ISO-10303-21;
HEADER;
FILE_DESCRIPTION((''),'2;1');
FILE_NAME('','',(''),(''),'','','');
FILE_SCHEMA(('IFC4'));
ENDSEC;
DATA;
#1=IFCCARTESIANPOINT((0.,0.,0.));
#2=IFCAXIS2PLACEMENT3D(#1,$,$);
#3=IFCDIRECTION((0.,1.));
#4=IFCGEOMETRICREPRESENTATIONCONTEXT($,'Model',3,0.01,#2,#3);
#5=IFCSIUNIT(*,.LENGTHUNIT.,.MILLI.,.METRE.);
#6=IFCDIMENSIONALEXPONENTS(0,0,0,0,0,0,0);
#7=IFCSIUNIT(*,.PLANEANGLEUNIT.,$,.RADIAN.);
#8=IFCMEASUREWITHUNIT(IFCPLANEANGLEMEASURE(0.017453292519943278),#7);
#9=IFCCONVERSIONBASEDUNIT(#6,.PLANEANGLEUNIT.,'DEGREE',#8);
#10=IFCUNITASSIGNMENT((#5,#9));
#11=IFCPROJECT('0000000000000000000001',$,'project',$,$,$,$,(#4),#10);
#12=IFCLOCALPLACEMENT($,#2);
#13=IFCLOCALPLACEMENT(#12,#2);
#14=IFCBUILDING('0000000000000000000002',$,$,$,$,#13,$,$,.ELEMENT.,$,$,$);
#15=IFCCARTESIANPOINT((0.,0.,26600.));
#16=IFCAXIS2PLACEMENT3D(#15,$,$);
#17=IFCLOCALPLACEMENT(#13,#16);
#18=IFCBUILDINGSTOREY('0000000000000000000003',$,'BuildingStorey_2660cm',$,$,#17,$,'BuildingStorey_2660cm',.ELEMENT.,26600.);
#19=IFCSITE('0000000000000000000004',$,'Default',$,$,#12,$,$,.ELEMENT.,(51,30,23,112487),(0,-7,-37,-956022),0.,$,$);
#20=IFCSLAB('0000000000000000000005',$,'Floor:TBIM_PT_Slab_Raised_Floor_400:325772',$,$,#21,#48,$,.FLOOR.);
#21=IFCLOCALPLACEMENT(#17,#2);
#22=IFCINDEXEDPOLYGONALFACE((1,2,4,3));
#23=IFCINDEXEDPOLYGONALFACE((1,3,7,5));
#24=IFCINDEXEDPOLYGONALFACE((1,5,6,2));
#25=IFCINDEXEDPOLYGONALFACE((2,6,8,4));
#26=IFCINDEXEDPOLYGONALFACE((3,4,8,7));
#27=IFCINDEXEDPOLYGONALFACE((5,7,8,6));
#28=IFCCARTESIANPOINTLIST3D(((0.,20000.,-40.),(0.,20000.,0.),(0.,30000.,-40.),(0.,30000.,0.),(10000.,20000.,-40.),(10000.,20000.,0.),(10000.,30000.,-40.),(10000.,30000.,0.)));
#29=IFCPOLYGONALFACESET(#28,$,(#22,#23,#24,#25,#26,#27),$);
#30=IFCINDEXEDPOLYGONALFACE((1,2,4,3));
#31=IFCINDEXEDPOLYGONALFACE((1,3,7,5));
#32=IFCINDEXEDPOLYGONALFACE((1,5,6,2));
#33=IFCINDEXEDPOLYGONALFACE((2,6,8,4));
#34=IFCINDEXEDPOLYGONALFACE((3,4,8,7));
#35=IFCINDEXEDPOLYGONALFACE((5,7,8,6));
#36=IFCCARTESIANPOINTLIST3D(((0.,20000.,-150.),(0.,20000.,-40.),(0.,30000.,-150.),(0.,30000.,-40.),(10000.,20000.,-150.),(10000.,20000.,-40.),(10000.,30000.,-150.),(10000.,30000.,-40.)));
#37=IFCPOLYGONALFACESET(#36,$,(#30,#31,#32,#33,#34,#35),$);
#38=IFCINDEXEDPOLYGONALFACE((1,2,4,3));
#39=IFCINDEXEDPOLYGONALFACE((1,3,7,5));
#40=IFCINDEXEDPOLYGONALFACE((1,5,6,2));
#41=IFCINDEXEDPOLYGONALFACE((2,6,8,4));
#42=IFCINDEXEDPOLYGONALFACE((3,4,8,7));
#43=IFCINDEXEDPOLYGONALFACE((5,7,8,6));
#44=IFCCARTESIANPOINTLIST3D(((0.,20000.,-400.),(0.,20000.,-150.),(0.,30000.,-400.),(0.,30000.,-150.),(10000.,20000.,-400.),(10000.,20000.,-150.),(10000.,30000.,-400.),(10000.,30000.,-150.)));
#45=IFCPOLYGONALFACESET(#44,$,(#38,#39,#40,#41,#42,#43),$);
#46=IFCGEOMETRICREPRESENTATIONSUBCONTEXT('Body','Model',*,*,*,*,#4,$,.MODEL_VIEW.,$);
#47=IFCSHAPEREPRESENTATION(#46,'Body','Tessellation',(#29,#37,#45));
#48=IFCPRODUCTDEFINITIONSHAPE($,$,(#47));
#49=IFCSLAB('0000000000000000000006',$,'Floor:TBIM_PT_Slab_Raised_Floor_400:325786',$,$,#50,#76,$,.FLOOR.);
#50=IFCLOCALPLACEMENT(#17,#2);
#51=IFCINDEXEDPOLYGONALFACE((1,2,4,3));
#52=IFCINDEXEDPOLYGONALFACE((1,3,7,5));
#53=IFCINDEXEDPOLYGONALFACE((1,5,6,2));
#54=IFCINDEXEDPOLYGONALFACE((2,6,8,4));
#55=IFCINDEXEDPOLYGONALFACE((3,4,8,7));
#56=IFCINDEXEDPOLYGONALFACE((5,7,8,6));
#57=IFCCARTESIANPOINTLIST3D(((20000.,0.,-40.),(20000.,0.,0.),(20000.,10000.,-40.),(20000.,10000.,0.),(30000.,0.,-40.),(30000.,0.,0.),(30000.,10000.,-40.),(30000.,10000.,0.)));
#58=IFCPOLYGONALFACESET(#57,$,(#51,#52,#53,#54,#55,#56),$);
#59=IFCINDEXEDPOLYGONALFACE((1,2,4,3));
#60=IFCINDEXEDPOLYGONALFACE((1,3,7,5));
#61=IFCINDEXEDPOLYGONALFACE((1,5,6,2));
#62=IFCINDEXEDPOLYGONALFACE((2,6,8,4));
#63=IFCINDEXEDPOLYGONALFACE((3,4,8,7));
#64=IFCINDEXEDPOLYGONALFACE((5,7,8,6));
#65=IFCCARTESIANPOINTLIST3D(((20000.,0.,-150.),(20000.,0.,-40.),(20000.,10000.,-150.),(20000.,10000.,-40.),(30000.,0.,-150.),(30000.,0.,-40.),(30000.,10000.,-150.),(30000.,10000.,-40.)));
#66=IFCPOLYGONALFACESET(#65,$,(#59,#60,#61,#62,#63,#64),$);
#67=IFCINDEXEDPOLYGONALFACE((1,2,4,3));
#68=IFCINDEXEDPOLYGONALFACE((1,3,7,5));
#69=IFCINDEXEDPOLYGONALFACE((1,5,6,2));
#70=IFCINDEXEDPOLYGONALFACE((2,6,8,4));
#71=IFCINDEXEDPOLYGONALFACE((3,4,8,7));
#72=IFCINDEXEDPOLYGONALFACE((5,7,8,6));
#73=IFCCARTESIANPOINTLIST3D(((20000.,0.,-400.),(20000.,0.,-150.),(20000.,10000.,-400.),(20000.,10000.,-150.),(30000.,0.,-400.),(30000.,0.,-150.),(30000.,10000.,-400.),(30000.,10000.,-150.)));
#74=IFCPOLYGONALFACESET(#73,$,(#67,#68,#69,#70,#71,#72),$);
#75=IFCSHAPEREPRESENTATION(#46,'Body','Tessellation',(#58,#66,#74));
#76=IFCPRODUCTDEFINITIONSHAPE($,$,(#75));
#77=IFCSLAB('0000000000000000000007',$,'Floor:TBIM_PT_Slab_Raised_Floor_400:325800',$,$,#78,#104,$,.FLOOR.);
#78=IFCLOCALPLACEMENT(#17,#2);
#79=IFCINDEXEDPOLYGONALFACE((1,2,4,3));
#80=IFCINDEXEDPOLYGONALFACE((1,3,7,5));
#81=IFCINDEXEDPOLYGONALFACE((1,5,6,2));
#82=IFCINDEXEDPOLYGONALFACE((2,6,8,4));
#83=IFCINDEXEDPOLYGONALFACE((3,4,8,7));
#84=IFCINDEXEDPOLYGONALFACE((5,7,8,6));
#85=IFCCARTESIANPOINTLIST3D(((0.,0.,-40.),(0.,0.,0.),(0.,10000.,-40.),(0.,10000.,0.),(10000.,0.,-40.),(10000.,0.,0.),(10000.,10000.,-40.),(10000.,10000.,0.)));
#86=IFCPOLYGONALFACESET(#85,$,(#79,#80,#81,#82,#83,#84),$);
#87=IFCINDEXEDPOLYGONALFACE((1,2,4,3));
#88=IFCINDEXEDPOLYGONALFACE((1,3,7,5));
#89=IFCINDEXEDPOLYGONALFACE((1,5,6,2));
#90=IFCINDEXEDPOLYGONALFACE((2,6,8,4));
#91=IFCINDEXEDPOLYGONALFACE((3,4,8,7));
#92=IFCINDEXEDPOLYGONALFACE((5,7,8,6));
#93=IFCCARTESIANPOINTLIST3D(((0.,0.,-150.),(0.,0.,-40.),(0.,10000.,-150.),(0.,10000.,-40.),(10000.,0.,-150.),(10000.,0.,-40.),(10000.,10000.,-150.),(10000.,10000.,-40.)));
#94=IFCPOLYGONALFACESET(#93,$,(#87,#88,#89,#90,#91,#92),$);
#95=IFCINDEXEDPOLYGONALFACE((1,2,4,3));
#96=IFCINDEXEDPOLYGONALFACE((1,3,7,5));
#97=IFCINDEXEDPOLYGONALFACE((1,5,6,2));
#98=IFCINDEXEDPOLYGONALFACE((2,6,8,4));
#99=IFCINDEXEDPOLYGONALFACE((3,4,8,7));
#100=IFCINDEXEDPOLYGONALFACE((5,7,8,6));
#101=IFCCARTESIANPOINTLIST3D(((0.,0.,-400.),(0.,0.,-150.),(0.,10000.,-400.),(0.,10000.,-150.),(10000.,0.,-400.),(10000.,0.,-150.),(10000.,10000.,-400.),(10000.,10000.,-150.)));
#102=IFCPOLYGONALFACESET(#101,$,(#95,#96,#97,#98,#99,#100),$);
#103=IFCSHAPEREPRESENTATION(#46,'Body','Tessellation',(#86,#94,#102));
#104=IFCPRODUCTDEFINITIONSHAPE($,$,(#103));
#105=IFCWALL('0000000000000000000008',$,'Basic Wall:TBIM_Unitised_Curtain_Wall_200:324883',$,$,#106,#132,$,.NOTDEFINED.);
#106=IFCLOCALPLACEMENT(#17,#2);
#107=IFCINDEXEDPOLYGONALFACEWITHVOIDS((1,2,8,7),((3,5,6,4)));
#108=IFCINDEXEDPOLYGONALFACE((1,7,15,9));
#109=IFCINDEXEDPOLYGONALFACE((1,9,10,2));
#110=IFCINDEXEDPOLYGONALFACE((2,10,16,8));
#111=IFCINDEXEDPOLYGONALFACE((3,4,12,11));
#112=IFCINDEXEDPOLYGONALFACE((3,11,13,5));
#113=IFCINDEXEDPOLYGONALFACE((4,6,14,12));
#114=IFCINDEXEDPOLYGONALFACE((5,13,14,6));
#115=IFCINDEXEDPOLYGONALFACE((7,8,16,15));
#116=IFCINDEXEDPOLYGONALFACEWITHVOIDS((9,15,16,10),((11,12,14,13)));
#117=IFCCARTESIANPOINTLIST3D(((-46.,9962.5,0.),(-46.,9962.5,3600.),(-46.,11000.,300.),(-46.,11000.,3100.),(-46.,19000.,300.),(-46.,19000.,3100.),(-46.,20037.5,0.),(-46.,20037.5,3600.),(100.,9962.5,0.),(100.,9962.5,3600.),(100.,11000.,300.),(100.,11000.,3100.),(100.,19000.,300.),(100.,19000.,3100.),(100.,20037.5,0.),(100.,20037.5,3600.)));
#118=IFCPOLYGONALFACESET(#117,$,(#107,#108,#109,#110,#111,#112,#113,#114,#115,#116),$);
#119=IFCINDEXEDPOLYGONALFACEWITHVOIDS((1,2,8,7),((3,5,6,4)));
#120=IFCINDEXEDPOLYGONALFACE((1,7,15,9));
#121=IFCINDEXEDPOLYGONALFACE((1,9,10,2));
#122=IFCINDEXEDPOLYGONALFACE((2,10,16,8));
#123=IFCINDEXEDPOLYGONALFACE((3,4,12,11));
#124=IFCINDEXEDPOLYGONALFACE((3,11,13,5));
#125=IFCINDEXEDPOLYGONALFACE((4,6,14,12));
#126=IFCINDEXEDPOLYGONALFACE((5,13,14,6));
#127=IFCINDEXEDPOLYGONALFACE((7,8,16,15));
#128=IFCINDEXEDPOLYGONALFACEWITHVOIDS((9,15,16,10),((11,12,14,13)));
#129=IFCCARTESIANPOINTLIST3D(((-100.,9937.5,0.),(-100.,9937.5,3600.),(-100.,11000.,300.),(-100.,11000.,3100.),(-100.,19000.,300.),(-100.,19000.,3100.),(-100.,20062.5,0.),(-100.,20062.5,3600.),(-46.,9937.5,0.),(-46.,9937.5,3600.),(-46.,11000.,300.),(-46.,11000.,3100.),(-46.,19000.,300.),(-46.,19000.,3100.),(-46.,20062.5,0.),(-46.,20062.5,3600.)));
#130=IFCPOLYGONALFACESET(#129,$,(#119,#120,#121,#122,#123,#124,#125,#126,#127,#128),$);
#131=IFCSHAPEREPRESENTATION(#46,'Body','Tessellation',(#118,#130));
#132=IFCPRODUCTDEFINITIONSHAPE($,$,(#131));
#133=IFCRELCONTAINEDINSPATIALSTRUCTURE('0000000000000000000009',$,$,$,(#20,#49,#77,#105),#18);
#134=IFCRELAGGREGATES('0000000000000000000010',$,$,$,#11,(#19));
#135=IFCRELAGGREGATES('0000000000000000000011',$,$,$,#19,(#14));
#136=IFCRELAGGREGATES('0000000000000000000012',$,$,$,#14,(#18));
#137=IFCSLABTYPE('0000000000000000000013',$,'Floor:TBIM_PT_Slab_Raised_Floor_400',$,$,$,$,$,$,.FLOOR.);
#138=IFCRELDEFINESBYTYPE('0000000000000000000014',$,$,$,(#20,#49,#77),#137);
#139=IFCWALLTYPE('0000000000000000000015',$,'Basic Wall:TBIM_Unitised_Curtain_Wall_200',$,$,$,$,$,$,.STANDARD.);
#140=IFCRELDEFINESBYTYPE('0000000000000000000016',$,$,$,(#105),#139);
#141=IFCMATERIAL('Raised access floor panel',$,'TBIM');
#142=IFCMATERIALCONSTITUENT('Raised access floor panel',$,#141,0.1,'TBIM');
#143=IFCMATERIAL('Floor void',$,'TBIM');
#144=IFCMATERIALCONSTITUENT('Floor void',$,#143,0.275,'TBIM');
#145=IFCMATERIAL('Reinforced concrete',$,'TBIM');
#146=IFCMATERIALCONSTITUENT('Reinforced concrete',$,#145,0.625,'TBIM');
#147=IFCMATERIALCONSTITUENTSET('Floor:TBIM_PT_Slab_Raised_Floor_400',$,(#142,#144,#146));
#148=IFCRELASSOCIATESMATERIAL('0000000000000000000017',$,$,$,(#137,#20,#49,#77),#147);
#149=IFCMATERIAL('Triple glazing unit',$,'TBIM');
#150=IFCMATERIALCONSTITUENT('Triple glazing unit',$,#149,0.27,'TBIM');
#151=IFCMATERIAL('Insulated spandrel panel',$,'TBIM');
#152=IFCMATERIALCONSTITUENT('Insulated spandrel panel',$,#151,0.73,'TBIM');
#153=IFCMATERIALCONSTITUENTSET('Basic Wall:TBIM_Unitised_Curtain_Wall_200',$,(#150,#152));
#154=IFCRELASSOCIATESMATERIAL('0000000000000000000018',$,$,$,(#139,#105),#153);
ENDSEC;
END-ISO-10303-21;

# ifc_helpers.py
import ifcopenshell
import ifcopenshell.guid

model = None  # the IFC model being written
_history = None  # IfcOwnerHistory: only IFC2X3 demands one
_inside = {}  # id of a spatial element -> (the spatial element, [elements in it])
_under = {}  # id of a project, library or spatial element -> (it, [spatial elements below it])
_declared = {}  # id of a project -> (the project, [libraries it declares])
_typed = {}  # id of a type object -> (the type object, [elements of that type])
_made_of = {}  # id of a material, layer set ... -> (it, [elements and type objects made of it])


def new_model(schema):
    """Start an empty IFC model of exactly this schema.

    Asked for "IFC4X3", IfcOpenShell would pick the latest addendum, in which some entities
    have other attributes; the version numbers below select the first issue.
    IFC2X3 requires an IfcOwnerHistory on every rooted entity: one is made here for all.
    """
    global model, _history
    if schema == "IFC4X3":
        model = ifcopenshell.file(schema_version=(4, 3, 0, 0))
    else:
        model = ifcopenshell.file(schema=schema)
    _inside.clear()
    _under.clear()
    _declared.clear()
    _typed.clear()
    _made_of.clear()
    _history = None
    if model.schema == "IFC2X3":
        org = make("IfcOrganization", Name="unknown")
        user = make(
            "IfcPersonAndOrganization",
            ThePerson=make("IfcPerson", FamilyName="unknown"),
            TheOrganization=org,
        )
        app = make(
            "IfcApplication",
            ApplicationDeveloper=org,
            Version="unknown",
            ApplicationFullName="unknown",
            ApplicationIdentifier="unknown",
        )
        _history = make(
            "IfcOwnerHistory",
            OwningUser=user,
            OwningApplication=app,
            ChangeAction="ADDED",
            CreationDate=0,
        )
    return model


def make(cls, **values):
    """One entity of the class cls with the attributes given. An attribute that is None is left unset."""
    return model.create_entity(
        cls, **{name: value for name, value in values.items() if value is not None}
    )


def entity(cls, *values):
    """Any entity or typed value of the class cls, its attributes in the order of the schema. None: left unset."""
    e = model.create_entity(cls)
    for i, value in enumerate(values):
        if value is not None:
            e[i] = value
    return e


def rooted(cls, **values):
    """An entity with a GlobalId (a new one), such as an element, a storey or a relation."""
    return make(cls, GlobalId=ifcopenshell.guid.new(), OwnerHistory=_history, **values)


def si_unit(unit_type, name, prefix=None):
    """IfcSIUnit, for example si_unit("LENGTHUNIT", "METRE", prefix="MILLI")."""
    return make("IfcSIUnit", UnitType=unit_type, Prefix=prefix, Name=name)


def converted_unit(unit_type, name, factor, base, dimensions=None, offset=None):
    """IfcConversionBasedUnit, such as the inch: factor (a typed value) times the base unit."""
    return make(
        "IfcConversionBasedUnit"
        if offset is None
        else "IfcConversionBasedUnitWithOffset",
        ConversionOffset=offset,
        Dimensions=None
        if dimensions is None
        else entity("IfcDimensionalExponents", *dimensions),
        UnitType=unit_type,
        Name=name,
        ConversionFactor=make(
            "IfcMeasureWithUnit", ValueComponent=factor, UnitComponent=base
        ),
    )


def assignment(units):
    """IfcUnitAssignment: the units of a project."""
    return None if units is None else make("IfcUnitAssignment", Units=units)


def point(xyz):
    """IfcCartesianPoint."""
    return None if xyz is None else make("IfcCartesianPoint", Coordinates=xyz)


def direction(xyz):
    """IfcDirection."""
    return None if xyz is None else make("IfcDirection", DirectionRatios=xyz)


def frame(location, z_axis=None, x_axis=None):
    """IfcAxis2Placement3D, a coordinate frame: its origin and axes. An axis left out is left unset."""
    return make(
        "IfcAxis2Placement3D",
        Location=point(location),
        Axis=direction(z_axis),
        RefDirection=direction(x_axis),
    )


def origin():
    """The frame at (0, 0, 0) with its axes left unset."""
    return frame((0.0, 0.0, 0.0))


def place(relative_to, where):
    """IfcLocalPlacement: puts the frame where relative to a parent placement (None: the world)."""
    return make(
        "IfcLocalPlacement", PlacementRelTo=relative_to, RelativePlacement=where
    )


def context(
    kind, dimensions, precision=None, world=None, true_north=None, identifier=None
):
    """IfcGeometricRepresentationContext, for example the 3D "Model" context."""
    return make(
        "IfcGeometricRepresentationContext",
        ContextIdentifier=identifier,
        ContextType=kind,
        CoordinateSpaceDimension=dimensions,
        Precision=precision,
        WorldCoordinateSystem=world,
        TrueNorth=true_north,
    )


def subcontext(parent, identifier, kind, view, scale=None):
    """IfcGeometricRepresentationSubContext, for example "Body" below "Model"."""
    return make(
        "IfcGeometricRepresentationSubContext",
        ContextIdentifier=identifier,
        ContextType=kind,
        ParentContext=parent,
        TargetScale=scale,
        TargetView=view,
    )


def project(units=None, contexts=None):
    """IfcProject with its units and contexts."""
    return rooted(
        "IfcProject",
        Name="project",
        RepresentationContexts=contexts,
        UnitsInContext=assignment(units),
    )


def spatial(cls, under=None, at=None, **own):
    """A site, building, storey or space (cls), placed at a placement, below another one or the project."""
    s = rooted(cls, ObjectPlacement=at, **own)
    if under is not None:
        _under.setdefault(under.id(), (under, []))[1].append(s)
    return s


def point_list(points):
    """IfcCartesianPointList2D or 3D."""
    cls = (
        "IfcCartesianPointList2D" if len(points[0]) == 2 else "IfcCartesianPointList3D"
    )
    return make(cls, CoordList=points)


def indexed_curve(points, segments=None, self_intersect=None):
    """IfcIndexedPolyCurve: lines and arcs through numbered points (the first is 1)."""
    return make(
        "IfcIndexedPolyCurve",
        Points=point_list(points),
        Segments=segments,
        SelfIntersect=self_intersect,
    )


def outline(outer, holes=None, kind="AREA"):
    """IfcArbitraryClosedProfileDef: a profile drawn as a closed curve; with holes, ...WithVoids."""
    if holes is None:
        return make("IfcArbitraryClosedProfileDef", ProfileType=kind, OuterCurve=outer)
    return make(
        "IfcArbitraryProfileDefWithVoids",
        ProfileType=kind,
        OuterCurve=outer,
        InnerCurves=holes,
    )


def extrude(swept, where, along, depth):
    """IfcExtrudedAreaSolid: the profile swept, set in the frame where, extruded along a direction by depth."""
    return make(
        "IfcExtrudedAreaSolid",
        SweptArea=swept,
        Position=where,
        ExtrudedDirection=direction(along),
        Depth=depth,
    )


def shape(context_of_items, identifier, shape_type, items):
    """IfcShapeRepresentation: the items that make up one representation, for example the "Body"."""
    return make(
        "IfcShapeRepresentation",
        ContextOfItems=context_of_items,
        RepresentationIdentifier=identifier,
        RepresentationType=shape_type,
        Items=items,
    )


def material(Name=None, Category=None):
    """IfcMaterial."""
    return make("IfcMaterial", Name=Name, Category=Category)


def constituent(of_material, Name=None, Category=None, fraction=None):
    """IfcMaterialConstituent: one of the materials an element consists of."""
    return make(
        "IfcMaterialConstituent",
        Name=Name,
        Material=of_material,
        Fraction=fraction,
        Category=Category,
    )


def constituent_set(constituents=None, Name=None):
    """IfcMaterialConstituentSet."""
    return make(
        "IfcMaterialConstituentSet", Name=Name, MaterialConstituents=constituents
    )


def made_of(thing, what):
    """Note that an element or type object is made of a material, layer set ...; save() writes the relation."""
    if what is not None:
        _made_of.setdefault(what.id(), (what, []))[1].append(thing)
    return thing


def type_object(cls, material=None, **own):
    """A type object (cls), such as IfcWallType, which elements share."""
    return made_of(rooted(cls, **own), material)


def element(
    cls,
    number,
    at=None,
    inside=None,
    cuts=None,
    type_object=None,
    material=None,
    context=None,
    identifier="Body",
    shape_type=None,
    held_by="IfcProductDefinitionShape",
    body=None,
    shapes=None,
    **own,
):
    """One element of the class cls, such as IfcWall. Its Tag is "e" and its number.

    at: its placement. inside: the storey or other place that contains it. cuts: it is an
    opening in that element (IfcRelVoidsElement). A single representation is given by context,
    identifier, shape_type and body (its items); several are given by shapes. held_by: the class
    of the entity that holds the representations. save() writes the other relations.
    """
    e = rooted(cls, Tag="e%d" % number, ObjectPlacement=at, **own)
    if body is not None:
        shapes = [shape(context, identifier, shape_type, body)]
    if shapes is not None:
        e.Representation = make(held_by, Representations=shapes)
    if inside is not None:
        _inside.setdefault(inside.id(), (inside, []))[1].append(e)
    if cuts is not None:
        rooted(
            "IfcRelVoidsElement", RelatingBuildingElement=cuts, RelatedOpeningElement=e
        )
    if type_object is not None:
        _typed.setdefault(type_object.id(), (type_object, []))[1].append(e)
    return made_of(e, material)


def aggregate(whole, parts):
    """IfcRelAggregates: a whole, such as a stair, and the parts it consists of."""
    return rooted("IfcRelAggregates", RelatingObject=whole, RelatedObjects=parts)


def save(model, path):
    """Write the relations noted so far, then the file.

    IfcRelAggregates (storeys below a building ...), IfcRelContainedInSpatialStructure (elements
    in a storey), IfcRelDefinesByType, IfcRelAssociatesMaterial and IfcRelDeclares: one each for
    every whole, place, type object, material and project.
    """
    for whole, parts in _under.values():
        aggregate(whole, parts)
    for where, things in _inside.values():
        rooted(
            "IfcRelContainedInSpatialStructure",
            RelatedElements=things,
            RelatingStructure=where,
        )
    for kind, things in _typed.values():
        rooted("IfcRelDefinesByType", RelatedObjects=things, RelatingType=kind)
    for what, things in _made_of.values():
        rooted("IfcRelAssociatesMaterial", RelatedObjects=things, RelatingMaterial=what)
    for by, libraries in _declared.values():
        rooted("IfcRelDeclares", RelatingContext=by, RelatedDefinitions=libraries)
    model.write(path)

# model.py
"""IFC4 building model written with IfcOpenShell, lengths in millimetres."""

from ifc_helpers import new_model, entity, si_unit, converted_unit, direction, frame, origin, place, context, subcontext, project, spatial, indexed_curve, outline, extrude, material, constituent, constituent_set, type_object, element, save


model = new_model("IFC4")

# Units and contexts
model_context = context("Model", 3, precision=0.01, world=origin(), true_north=direction((0.0, 1.0)))
body_context = subcontext(model_context, "Body", "Model", "MODEL_VIEW")
ifc_project = project(units=[si_unit("LENGTHUNIT", "METRE", prefix="MILLI"), converted_unit("PLANEANGLEUNIT", "DEGREE", entity("IfcPlaneAngleMeasure", 0.017453292519943278), si_unit("PLANEANGLEUNIT", "RADIAN"), dimensions=[0, 0, 0, 0, 0, 0, 0])], contexts=[model_context])

# Site, building, storey
site_placement = place(None, origin())
site = spatial("IfcSite", under=ifc_project, at=site_placement, Name="Default", CompositionType="ELEMENT", RefLatitude=(51, 30, 23, 112487), RefLongitude=(0, -7, -37, -956022), RefElevation=0.0)
building_placement = place(site_placement, origin())
building = spatial("IfcBuilding", under=site, at=building_placement, CompositionType="ELEMENT")
storey_placement = place(building_placement, frame((0.0, 0.0, 26600.0)))
storey = spatial("IfcBuildingStorey", under=building, at=storey_placement, Name="BuildingStorey_2660cm", LongName="BuildingStorey_2660cm", CompositionType="ELEMENT", Elevation=26600.0)

# Slabs
ifc_material_1 = material(Name="Raised access floor panel", Category="TBIM")
ifc_constituent_1 = constituent(ifc_material_1, Name="Raised access floor panel", Category="TBIM", fraction=0.1)
ifc_material_2 = material(Name="Floor void", Category="TBIM")
ifc_constituent_2 = constituent(ifc_material_2, Name="Floor void", Category="TBIM", fraction=0.275)
ifc_material_3 = material(Name="Reinforced concrete", Category="TBIM")
ifc_constituent_3 = constituent(ifc_material_3, Name="Reinforced concrete", Category="TBIM", fraction=0.625)
ifc_constituent_set_1 = constituent_set(constituents=[ifc_constituent_1, ifc_constituent_2, ifc_constituent_3], Name="Floor:TBIM_PT_Slab_Raised_Floor_400")
slab_type = type_object("IfcSlabType", Name="Floor:TBIM_PT_Slab_Raised_Floor_400", PredefinedType="FLOOR", material=ifc_constituent_set_1)
slab_1_placement = place(storey_placement, origin())
element("IfcSlab", 1, at=slab_1_placement, inside=storey, type_object=slab_type, material=ifc_constituent_set_1, Name="Floor:TBIM_PT_Slab_Raised_Floor_400:325772", PredefinedType="FLOOR", context=body_context, shape_type="SweptSolid", body=[
    extrude(outline(indexed_curve([(-5000.0, -5000.0), (5000.0, -5000.0), (5000.0, 5000.0), (-5000.0, 5000.0), (-5000.0, -5000.0)], self_intersect=False)), frame((5000.0, 25000.0, -40.0), z_axis=(0.0, 0.0, 1.0), x_axis=(-1.0, 0.0, 0.0)), (0.0, 0.0, 1.0), 40.0),
    extrude(outline(indexed_curve([(-5000.0, -5000.0), (5000.0, -5000.0), (5000.0, 5000.0), (-5000.0, 5000.0), (-5000.0, -5000.0)], self_intersect=False)), frame((5000.0, 25000.0, -150.0), z_axis=(0.0, 0.0, 1.0), x_axis=(-1.0, 0.0, 0.0)), (0.0, 0.0, 1.0), 110.0),
    extrude(outline(indexed_curve([(-5000.0, -5000.0), (5000.0, -5000.0), (5000.0, 5000.0), (-5000.0, 5000.0), (-5000.0, -5000.0)], self_intersect=False)), frame((5000.0, 25000.0, -400.0), z_axis=(0.0, 0.0, 1.0), x_axis=(-1.0, 0.0, 0.0)), (0.0, 0.0, 1.0), 250.0),
])
slab_2_placement = place(storey_placement, origin())
element("IfcSlab", 2, at=slab_2_placement, inside=storey, type_object=slab_type, material=ifc_constituent_set_1, Name="Floor:TBIM_PT_Slab_Raised_Floor_400:325786", PredefinedType="FLOOR", context=body_context, shape_type="SweptSolid", body=[
    extrude(outline(indexed_curve([(-5000.0, -5000.0), (5000.0, -5000.0), (5000.0, 5000.0), (-5000.0, 5000.0), (-5000.0, -5000.0)], self_intersect=False)), frame((25000.0, 5000.0, -40.0), z_axis=(0.0, 0.0, 1.0), x_axis=(-1.0, 0.0, 0.0)), (0.0, 0.0, 1.0), 40.0),
    extrude(outline(indexed_curve([(-5000.0, -5000.0), (5000.0, -5000.0), (5000.0, 5000.0), (-5000.0, 5000.0), (-5000.0, -5000.0)], self_intersect=False)), frame((25000.0, 5000.0, -150.0), z_axis=(0.0, 0.0, 1.0), x_axis=(-1.0, 0.0, 0.0)), (0.0, 0.0, 1.0), 110.0),
    extrude(outline(indexed_curve([(-5000.0, -5000.0), (5000.0, -5000.0), (5000.0, 5000.0), (-5000.0, 5000.0), (-5000.0, -5000.0)], self_intersect=False)), frame((25000.0, 5000.0, -400.0), z_axis=(0.0, 0.0, 1.0), x_axis=(-1.0, 0.0, 0.0)), (0.0, 0.0, 1.0), 250.0),
])
slab_3_placement = place(storey_placement, origin())
element("IfcSlab", 3, at=slab_3_placement, inside=storey, type_object=slab_type, material=ifc_constituent_set_1, Name="Floor:TBIM_PT_Slab_Raised_Floor_400:325800", PredefinedType="FLOOR", context=body_context, shape_type="SweptSolid", body=[
    extrude(outline(indexed_curve([(-5000.0, -5000.0), (5000.0, -5000.0), (5000.0, 5000.0), (-5000.0, 5000.0), (-5000.0, -5000.0)], self_intersect=False)), frame((5000.0, 5000.0, -40.0), z_axis=(0.0, 0.0, 1.0), x_axis=(-1.0, 0.0, 0.0)), (0.0, 0.0, 1.0), 40.0),
    extrude(outline(indexed_curve([(-5000.0, -5000.0), (5000.0, -5000.0), (5000.0, 5000.0), (-5000.0, 5000.0), (-5000.0, -5000.0)], self_intersect=False)), frame((5000.0, 5000.0, -150.0), z_axis=(0.0, 0.0, 1.0), x_axis=(-1.0, 0.0, 0.0)), (0.0, 0.0, 1.0), 110.0),
    extrude(outline(indexed_curve([(-5000.0, -5000.0), (5000.0, -5000.0), (5000.0, 5000.0), (-5000.0, 5000.0), (-5000.0, -5000.0)], self_intersect=False)), frame((5000.0, 5000.0, -400.0), z_axis=(0.0, 0.0, 1.0), x_axis=(-1.0, 0.0, 0.0)), (0.0, 0.0, 1.0), 250.0),
])

# Wall, opening
ifc_material_4 = material(Name="Triple glazing unit", Category="TBIM")
ifc_constituent_4 = constituent(ifc_material_4, Name="Triple glazing unit", Category="TBIM", fraction=0.27)
ifc_material_5 = material(Name="Insulated spandrel panel", Category="TBIM")
ifc_constituent_5 = constituent(ifc_material_5, Name="Insulated spandrel panel", Category="TBIM", fraction=0.73)
ifc_constituent_set_2 = constituent_set(constituents=[ifc_constituent_4, ifc_constituent_5], Name="Basic Wall:TBIM_Unitised_Curtain_Wall_200")
wall_type = type_object("IfcWallType", Name="Basic Wall:TBIM_Unitised_Curtain_Wall_200", PredefinedType="STANDARD", material=ifc_constituent_set_2)
wall_1_placement = place(storey_placement, frame((0.0, 9937.5, 0.0), z_axis=(0.0, 0.0, 1.0), x_axis=(0.0, 1.0, 0.0)))
wall_1 = element("IfcWall", 4, at=wall_1_placement, inside=storey, type_object=wall_type, material=ifc_constituent_set_2, Name="Basic Wall:TBIM_Unitised_Curtain_Wall_200:324883", PredefinedType="NOTDEFINED", context=body_context, shape_type="SweptSolid", body=[
    extrude(outline(indexed_curve([(-1800.0, -5037.5), (1800.0, -5037.5), (1800.0, 5037.5), (-1800.0, 5037.5), (-1800.0, -5037.5)], self_intersect=False), holes=[indexed_curve([(1300.0, 4000.0), (1300.0, -4000.0), (-1500.0, -4000.0), (-1500.0, 4000.0), (1300.0, 4000.0)], self_intersect=False)]), frame((5062.5, 46.0, 1800.0), z_axis=(0.0, -1.0, 0.0), x_axis=(0.0, 0.0, 1.0)), (0.0, 0.0, 1.0), 146.0),
    extrude(outline(indexed_curve([(-5062.5, -1800.0), (5062.5, -1800.0), (5062.5, 1800.0), (-5062.5, 1800.0), (-5062.5, -1800.0)], self_intersect=False), holes=[indexed_curve([(-4000.0, 1300.0), (4000.0, 1300.0), (4000.0, -1500.0), (-4000.0, -1500.0), (-4000.0, 1300.0)], self_intersect=False)]), frame((5062.5, 100.0, 1800.0), z_axis=(0.0, -1.0, 0.0), x_axis=(1.0, 0.0, 0.0)), (0.0, 0.0, 1.0), 54.0),
])
opening_1_placement = place(wall_1_placement, frame((1062.5, -100.0, 300.0)))
element("IfcOpeningElement", 5, at=opening_1_placement, cuts=wall_1, PredefinedType="OPENING", context=body_context, shape_type="SweptSolid", body=[
    extrude(outline(indexed_curve([(2800.0, 0.0), (2800.0, 8000.0), (0.0, 8000.0), (0.0, 0.0), (2800.0, 0.0)], self_intersect=False)), frame((0.0, 0.0, 0.0), z_axis=(0.0, 1.0, 0.0), x_axis=(0.0, 0.0, 1.0)), (0.0, 0.0, 1.0), 200.0),
])

save(model, "model.ifc")
